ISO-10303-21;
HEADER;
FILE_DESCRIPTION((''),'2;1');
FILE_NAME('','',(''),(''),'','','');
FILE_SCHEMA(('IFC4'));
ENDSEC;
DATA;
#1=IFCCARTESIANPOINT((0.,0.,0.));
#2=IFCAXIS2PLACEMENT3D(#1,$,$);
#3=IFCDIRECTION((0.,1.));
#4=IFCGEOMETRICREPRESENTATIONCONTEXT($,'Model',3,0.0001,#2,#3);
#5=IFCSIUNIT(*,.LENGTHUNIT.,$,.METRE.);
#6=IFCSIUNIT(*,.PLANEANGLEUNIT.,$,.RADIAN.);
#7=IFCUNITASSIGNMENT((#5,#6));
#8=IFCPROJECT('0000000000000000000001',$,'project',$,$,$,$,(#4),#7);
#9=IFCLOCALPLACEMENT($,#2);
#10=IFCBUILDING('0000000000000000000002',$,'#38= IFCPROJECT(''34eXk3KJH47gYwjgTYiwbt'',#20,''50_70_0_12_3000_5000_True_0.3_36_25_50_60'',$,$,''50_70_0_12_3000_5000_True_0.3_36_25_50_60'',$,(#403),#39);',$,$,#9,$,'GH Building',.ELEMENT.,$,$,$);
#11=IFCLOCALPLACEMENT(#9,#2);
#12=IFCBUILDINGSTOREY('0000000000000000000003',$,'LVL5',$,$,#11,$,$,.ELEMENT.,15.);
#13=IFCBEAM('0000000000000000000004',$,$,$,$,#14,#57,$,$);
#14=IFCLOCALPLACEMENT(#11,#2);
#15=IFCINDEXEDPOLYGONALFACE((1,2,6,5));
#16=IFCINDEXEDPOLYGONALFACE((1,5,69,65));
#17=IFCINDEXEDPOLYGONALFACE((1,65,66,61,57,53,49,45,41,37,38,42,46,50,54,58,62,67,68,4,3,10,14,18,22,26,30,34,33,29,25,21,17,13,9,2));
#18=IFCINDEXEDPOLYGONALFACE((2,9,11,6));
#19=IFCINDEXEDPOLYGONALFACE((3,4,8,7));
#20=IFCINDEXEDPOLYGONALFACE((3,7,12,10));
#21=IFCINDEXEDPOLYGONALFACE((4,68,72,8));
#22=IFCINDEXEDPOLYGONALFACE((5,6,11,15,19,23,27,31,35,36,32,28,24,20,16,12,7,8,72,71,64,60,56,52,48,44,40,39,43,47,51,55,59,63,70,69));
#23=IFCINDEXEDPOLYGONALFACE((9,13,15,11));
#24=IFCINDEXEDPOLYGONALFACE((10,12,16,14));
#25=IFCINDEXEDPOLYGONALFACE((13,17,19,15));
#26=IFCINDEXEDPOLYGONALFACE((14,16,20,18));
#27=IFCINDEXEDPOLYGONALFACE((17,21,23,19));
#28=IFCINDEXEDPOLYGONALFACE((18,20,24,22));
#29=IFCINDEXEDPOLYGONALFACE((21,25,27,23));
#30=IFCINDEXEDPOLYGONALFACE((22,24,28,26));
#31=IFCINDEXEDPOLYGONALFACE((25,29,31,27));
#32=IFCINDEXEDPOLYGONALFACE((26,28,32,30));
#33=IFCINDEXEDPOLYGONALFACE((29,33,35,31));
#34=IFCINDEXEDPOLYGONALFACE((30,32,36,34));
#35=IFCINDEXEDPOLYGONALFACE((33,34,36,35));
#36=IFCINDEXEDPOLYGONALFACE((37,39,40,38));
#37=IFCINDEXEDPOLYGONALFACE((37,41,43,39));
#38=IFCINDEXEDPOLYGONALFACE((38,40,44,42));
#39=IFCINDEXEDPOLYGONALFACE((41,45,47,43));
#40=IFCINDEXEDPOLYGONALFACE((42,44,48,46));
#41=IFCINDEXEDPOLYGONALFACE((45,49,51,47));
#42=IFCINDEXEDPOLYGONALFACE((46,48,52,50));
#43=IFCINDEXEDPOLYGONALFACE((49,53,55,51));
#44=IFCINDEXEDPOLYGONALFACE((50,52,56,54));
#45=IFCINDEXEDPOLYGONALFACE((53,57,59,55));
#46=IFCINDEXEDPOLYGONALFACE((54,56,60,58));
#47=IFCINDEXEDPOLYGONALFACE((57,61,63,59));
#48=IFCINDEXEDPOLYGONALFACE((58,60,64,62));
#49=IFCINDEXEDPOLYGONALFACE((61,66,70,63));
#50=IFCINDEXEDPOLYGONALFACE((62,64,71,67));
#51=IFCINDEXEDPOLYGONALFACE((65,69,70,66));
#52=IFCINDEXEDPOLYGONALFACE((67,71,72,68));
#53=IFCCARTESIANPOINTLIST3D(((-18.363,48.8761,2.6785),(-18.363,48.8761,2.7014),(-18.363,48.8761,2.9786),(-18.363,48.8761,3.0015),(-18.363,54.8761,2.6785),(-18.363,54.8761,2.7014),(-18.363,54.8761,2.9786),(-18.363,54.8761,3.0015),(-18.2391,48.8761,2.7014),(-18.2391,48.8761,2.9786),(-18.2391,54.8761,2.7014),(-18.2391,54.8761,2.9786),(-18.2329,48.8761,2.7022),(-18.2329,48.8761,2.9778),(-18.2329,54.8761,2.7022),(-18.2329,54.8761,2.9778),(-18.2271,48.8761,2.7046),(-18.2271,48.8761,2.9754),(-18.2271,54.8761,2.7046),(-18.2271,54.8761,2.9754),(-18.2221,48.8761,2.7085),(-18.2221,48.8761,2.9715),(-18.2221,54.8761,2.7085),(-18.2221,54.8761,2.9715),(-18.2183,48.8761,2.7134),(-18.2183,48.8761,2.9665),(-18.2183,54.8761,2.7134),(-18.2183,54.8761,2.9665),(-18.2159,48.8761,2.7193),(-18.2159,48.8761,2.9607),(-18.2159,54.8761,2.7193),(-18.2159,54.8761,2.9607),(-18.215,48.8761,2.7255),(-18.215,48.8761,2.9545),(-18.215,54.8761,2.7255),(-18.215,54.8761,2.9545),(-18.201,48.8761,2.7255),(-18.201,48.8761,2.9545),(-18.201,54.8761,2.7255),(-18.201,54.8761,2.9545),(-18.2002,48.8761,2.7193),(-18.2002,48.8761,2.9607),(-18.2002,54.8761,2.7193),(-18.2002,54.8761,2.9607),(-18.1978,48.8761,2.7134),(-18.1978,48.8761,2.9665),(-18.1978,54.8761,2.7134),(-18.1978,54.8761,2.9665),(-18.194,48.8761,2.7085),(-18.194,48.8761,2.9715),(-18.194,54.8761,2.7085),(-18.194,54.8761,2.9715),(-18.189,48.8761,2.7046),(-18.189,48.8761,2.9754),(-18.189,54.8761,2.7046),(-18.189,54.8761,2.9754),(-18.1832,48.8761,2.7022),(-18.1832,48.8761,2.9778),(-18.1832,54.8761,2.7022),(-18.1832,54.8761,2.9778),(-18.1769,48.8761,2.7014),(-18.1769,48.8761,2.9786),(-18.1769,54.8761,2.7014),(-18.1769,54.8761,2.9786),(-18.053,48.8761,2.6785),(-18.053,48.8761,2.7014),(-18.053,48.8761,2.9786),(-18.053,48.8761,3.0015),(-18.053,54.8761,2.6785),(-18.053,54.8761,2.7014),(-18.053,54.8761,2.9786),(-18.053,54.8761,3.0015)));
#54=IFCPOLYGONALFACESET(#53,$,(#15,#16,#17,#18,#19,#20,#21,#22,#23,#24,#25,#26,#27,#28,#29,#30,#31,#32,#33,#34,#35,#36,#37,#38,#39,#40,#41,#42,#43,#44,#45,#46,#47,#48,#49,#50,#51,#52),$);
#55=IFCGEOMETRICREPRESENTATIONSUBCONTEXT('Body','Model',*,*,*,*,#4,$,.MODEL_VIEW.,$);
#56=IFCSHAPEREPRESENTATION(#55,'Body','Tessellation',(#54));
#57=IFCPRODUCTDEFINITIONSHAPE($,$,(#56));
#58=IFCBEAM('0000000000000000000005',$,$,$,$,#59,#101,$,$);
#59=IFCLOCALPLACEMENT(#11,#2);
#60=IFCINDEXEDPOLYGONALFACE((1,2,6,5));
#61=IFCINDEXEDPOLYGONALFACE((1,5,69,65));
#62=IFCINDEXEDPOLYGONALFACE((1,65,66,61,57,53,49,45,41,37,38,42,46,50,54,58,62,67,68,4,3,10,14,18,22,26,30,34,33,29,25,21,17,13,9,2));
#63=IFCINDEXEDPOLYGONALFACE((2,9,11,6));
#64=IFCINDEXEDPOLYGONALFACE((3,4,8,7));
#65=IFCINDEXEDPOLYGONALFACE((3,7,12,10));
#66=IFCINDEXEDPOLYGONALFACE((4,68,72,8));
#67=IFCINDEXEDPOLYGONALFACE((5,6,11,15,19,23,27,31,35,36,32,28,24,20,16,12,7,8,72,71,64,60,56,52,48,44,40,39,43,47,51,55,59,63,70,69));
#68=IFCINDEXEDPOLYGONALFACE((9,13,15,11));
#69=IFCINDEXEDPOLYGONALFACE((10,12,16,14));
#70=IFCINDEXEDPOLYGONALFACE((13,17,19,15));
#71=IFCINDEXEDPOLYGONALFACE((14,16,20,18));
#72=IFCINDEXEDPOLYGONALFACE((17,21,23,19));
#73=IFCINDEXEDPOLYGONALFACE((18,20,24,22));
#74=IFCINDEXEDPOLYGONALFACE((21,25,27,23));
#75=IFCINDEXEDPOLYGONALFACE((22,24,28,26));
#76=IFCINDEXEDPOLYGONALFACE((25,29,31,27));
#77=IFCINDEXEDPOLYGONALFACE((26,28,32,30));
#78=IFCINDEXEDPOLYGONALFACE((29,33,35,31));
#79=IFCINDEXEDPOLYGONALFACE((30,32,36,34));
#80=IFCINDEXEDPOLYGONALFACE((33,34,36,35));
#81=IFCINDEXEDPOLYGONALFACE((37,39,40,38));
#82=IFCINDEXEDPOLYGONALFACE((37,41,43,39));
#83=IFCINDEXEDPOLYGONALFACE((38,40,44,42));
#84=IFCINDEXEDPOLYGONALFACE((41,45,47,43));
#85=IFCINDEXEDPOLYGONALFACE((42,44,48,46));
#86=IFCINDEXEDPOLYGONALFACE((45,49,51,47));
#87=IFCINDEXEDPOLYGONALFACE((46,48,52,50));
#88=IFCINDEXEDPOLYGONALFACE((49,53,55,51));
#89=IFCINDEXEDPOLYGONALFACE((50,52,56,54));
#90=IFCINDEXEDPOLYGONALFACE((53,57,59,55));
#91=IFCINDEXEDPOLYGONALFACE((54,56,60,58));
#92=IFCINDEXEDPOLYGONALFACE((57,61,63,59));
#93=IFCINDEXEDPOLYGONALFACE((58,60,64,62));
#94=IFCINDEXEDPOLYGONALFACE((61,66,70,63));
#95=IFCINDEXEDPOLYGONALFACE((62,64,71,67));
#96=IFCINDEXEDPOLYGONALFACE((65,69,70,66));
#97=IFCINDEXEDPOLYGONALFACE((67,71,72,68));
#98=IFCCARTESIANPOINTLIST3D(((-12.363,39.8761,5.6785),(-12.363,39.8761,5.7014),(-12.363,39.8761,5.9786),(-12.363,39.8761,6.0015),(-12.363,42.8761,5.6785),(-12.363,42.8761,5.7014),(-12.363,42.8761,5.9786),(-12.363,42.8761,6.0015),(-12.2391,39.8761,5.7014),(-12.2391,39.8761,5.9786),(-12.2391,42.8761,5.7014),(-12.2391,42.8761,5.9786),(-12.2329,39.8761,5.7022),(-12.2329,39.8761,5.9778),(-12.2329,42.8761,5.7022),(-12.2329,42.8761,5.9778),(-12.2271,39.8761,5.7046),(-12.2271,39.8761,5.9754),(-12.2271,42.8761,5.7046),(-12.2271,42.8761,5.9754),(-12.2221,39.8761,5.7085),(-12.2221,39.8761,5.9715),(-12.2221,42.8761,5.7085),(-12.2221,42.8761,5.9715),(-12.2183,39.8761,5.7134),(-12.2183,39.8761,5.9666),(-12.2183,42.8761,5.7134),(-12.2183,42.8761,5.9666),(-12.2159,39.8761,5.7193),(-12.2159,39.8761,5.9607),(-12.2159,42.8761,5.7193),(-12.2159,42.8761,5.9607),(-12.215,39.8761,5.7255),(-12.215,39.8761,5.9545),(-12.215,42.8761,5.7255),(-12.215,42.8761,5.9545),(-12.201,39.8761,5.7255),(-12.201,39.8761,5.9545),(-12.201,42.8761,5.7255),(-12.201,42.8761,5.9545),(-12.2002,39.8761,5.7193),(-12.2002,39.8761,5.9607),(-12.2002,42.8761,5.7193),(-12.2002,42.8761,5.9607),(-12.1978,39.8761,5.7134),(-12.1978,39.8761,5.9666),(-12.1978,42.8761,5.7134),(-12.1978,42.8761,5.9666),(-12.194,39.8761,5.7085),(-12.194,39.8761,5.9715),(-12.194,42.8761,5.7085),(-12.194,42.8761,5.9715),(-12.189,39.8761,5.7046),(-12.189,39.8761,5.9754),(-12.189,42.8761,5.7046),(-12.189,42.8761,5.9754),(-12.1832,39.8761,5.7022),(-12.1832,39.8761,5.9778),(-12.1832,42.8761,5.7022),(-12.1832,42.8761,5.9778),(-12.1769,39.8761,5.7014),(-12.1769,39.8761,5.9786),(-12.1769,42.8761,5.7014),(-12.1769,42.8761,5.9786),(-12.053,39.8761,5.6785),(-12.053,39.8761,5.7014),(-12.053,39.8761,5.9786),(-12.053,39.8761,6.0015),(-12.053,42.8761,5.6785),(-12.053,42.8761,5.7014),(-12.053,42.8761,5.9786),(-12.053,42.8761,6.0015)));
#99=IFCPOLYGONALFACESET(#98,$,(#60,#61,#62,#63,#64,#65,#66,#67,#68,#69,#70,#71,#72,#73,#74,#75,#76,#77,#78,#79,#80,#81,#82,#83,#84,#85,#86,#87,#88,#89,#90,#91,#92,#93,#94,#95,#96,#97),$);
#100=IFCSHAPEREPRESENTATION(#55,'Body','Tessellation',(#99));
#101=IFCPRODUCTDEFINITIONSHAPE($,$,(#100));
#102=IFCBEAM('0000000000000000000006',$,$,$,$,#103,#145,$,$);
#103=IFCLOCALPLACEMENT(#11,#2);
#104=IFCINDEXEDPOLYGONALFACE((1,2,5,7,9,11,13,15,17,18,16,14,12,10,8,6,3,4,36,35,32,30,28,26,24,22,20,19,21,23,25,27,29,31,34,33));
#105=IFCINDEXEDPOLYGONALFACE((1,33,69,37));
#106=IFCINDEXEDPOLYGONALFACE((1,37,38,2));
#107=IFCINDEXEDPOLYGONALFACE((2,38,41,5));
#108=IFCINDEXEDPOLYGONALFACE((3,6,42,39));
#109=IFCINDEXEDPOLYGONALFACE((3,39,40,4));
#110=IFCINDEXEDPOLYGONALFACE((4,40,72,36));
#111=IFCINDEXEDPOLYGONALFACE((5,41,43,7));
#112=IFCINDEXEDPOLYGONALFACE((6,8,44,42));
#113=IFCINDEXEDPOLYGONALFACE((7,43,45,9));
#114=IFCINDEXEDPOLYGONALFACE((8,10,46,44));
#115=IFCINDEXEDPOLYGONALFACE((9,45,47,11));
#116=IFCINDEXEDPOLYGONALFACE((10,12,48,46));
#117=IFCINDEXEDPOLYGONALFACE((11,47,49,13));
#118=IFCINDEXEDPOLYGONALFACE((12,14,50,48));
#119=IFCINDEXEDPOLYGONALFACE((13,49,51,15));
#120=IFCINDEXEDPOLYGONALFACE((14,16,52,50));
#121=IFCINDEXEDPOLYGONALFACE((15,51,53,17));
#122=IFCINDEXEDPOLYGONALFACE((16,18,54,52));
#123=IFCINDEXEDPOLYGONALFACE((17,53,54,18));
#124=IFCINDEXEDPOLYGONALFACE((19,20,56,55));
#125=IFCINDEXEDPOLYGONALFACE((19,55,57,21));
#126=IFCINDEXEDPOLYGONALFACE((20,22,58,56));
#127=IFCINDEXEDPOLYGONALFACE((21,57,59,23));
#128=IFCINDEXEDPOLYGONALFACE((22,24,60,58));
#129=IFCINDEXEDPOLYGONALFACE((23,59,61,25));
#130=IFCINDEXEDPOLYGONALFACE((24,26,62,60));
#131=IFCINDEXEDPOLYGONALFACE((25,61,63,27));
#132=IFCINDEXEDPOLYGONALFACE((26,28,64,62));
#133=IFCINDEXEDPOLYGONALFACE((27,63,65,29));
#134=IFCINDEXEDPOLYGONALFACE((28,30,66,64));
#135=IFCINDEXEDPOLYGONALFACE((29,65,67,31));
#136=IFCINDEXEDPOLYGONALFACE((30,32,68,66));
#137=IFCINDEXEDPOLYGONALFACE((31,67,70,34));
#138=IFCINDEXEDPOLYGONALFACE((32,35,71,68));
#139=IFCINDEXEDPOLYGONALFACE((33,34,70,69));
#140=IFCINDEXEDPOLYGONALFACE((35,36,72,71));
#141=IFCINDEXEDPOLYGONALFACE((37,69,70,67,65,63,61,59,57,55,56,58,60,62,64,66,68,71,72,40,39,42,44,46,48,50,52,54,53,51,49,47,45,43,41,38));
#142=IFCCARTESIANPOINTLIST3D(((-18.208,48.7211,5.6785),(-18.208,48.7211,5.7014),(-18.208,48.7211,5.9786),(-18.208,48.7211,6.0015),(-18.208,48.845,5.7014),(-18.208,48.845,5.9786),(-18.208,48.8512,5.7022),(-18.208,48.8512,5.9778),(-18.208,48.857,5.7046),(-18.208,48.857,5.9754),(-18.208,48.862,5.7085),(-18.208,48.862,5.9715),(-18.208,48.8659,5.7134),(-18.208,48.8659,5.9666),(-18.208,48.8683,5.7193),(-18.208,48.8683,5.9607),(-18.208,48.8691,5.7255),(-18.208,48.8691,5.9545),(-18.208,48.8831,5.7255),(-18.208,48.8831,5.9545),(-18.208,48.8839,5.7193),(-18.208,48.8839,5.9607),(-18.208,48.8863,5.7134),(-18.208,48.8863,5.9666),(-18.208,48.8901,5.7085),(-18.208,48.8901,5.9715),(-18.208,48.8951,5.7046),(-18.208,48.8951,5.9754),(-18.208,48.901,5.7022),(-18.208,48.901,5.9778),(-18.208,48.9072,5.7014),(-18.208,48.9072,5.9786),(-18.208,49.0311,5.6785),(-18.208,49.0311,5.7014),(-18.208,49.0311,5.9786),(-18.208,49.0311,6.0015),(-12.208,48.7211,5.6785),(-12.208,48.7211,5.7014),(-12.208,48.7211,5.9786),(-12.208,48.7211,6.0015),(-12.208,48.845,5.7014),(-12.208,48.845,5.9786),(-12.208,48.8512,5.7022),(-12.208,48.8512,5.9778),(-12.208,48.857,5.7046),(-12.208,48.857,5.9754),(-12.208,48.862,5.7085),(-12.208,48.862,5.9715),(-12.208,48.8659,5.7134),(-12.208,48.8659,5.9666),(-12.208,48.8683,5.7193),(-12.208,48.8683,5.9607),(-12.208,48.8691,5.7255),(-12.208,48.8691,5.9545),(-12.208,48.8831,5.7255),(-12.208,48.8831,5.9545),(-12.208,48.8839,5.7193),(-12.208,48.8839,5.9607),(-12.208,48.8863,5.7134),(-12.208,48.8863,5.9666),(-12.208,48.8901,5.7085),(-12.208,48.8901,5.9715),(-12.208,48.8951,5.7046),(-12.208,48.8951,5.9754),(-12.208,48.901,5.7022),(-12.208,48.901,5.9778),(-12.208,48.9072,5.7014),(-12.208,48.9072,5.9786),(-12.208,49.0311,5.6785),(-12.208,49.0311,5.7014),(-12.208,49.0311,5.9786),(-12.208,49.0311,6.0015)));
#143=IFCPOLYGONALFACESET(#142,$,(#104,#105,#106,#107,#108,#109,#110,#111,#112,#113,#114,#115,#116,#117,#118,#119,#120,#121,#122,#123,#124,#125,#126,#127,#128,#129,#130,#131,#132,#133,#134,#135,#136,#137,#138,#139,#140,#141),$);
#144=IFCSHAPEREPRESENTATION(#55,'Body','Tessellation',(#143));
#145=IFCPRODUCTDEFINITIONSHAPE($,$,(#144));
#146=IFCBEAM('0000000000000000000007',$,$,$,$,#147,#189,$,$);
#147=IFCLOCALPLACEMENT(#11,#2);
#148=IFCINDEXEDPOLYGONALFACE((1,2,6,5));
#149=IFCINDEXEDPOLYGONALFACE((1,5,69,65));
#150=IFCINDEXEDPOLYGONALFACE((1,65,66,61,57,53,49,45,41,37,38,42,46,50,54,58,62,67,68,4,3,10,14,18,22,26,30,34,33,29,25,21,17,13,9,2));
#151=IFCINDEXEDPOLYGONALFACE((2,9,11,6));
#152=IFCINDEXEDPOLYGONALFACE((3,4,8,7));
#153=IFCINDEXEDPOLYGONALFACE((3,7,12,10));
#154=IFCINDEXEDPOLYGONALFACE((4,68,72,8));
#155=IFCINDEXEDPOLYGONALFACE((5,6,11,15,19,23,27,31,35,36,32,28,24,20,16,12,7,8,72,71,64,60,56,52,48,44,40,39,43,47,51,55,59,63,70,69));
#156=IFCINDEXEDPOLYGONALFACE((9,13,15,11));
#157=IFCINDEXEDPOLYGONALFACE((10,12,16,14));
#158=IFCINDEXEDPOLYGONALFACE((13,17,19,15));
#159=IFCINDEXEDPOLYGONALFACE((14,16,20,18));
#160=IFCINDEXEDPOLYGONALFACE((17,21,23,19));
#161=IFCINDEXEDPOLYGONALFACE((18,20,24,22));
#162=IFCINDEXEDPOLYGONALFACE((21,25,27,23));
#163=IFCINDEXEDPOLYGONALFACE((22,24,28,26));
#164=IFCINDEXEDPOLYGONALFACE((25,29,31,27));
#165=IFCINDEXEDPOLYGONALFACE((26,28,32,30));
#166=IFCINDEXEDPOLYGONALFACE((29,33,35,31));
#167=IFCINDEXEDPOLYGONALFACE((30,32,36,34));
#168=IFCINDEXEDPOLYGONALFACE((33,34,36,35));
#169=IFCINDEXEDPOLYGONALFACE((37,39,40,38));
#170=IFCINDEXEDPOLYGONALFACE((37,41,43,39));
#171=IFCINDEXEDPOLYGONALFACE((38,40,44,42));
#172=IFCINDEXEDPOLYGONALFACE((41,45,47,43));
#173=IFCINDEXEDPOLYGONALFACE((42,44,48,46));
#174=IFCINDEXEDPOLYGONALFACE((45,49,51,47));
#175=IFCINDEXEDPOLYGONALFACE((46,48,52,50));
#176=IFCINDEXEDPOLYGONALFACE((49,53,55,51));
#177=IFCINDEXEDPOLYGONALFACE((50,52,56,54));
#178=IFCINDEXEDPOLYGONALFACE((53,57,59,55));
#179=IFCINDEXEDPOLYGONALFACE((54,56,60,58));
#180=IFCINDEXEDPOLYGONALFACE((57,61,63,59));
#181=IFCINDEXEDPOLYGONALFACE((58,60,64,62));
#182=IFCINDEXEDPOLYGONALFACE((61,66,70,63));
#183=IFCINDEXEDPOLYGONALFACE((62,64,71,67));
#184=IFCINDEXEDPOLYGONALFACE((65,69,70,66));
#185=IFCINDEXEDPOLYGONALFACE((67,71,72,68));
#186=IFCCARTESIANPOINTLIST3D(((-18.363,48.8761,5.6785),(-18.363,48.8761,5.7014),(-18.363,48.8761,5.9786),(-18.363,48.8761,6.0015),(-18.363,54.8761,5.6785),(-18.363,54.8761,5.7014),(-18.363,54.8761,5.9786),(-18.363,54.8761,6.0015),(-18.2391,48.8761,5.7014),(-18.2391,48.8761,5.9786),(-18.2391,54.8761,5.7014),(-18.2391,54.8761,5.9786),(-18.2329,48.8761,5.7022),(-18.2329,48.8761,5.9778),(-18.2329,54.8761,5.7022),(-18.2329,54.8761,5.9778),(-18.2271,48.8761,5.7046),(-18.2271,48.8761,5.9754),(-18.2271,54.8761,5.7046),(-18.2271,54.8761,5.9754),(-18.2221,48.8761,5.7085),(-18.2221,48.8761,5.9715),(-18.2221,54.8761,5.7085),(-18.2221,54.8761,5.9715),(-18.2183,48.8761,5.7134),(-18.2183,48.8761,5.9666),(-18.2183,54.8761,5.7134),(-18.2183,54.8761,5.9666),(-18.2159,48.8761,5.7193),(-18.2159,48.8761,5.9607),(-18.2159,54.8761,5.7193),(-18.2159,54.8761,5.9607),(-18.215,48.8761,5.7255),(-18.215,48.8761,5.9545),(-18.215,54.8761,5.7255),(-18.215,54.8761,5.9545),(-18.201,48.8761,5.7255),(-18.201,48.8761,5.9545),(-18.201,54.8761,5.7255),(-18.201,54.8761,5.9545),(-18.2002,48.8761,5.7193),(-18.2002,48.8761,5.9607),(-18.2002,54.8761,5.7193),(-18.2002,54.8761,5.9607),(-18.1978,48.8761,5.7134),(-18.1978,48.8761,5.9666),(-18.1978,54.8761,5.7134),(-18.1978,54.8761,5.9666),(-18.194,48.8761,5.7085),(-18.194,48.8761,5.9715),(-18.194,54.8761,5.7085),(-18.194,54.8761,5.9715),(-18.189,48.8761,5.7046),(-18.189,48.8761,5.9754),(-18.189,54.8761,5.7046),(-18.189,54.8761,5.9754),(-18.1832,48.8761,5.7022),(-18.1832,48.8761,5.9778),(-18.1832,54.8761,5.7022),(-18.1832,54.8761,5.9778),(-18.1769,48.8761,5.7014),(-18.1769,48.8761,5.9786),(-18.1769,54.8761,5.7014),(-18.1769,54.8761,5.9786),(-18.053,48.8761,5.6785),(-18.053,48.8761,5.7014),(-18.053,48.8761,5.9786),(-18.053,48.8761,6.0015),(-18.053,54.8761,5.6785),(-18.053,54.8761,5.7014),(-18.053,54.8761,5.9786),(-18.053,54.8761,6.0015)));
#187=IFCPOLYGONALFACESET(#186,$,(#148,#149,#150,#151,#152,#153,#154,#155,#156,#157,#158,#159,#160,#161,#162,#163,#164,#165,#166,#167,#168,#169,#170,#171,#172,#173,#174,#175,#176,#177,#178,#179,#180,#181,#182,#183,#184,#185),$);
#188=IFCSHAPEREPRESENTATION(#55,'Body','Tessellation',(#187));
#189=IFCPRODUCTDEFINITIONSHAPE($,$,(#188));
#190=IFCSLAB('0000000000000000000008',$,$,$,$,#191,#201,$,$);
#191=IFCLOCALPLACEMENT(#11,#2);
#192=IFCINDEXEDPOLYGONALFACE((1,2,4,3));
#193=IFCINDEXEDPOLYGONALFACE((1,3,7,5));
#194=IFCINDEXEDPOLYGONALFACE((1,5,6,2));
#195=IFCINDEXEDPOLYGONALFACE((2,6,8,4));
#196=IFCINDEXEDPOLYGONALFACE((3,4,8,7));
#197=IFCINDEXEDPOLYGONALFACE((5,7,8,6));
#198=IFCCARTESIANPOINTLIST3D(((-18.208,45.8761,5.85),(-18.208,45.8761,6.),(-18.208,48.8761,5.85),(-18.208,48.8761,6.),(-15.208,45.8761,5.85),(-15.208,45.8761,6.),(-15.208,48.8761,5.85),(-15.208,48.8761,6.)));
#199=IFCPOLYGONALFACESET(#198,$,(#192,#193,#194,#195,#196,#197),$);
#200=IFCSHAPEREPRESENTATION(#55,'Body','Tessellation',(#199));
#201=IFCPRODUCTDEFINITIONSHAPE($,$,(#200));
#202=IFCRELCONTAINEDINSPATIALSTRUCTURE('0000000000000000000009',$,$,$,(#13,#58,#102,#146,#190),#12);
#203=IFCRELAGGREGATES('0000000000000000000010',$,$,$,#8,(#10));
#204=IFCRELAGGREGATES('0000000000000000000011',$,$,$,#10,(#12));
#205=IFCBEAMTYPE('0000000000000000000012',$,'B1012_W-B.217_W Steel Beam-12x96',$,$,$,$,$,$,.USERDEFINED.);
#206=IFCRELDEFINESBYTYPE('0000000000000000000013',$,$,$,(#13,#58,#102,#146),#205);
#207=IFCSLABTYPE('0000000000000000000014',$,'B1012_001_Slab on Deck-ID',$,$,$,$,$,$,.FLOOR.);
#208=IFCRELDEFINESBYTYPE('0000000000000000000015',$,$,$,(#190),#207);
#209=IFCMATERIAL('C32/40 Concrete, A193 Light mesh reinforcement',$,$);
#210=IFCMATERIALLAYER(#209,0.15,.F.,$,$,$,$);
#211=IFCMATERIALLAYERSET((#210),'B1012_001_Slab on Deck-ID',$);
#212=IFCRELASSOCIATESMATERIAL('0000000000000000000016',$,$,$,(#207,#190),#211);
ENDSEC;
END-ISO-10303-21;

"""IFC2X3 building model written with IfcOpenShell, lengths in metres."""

from ifc_helpers import new_model, si_unit, direction, frame, origin, origin_2d, place, context, subcontext, project, spatial, polyline, i_section, outline, extrude, material, layer, layer_set, layer_usage, type_object, element, save


model = new_model("IFC2X3")

# Units and contexts
model_context = context("Model", 3, precision=0.0001, world=origin(), true_north=direction((0.0, 1.0)))
body_context = subcontext(model_context, "Body", "Model", "MODEL_VIEW")
ifc_project = project(units=[si_unit("LENGTHUNIT", "METRE"), si_unit("PLANEANGLEUNIT", "RADIAN")], contexts=[model_context])

# Building, storey
building_placement = place(None, origin())
building = spatial("IfcBuilding", under=ifc_project, at=building_placement, Name="#38= IFCPROJECT('34eXk3KJH47gYwjgTYiwbt',#20,'50_70_0_12_3000_5000_True_0.3_36_25_50_60',$,$,'50_70_0_12_3000_5000_True_0.3_36_25_50_60',$,(#403),#39);", LongName="GH Building", CompositionType="ELEMENT")
storey_placement = place(building_placement, origin())
storey = spatial("IfcBuildingStorey", under=building, at=storey_placement, Name="LVL5", CompositionType="ELEMENT", Elevation=15.0)

# Beams
beam_type = type_object("IfcBeamType", Name="B1012_W-B.217_W Steel Beam-12x96", PredefinedType="USERDEFINED")
for number, where, z_axis, x_axis in (
    (1, (-18.208, 48.8761, 2.84), (0.0, 1.0, 0.0), (-1.0, 0.0, 0.0)),
):
    element("IfcBeam", number, at=place(storey_placement, frame(where, z_axis=z_axis, x_axis=x_axis)), inside=storey, type_object=beam_type, context=body_context, shape_type="SweptSolid", body=[
        extrude(i_section(OverallWidth=0.31, OverallDepth=0.323, WebThickness=0.014, FlangeThickness=0.0229, FilletRadius=0.0241, at=origin_2d()), origin(), (0.0, 0.0, 1.0), 6.0),
    ])
beam_1_placement = place(storey_placement, frame((-12.208, 39.8761, 5.84), z_axis=(0.0, 1.0, 0.0), x_axis=(-1.0, 0.0, 0.0)))
element("IfcBeam", 2, at=beam_1_placement, inside=storey, type_object=beam_type, context=body_context, shape_type="SweptSolid", body=[
    extrude(i_section(OverallWidth=0.31, OverallDepth=0.323, WebThickness=0.014, FlangeThickness=0.0229, FilletRadius=0.0241, at=origin_2d()), origin(), (0.0, 0.0, 1.0), 3.0),
])
for number, where, z_axis, x_axis in (
    (3, (-18.208, 48.8761, 5.84), (1.0, 0.0, 0.0), (0.0, 1.0, 0.0)),
    (4, (-18.208, 48.8761, 5.84), (0.0, 1.0, 0.0), (-1.0, 0.0, 0.0)),
):
    element("IfcBeam", number, at=place(storey_placement, frame(where, z_axis=z_axis, x_axis=x_axis)), inside=storey, type_object=beam_type, context=body_context, shape_type="SweptSolid", body=[
        extrude(i_section(OverallWidth=0.31, OverallDepth=0.323, WebThickness=0.014, FlangeThickness=0.0229, FilletRadius=0.0241, at=origin_2d()), origin(), (0.0, 0.0, 1.0), 6.0),
    ])

# Slab
ifc_material_1 = material(Name="C32/40 Concrete, A193 Light mesh reinforcement")
ifc_layer_1 = layer(ifc_material_1, 0.15, ventilated=False)
ifc_layer_set_1 = layer_set([ifc_layer_1], Name="B1012_001_Slab on Deck-ID")
ifc_layer_usage_1 = layer_usage(ifc_layer_set_1, "AXIS3", "NEGATIVE", -0.15)
slab_type_1 = type_object("IfcSlabType", Name="B1012_001_Slab on Deck-ID", PredefinedType="FLOOR", material=ifc_layer_set_1)
slab_1_placement = place(storey_placement, frame((-16.708, 47.3761, 5.85)))
element("IfcSlab", 5, at=slab_1_placement, inside=storey, type_object=slab_type_1, material=ifc_layer_usage_1, context=body_context, shape_type="SweptSolid", body=[
    extrude(outline(polyline([(-1.5, 1.5), (1.5, 1.5), (1.5, -1.5), (-1.5, -1.5), (-1.5, 1.5)])), origin(), (0.0, 0.0, 1.0), 0.15),
])

save(model, "model.ifc")
